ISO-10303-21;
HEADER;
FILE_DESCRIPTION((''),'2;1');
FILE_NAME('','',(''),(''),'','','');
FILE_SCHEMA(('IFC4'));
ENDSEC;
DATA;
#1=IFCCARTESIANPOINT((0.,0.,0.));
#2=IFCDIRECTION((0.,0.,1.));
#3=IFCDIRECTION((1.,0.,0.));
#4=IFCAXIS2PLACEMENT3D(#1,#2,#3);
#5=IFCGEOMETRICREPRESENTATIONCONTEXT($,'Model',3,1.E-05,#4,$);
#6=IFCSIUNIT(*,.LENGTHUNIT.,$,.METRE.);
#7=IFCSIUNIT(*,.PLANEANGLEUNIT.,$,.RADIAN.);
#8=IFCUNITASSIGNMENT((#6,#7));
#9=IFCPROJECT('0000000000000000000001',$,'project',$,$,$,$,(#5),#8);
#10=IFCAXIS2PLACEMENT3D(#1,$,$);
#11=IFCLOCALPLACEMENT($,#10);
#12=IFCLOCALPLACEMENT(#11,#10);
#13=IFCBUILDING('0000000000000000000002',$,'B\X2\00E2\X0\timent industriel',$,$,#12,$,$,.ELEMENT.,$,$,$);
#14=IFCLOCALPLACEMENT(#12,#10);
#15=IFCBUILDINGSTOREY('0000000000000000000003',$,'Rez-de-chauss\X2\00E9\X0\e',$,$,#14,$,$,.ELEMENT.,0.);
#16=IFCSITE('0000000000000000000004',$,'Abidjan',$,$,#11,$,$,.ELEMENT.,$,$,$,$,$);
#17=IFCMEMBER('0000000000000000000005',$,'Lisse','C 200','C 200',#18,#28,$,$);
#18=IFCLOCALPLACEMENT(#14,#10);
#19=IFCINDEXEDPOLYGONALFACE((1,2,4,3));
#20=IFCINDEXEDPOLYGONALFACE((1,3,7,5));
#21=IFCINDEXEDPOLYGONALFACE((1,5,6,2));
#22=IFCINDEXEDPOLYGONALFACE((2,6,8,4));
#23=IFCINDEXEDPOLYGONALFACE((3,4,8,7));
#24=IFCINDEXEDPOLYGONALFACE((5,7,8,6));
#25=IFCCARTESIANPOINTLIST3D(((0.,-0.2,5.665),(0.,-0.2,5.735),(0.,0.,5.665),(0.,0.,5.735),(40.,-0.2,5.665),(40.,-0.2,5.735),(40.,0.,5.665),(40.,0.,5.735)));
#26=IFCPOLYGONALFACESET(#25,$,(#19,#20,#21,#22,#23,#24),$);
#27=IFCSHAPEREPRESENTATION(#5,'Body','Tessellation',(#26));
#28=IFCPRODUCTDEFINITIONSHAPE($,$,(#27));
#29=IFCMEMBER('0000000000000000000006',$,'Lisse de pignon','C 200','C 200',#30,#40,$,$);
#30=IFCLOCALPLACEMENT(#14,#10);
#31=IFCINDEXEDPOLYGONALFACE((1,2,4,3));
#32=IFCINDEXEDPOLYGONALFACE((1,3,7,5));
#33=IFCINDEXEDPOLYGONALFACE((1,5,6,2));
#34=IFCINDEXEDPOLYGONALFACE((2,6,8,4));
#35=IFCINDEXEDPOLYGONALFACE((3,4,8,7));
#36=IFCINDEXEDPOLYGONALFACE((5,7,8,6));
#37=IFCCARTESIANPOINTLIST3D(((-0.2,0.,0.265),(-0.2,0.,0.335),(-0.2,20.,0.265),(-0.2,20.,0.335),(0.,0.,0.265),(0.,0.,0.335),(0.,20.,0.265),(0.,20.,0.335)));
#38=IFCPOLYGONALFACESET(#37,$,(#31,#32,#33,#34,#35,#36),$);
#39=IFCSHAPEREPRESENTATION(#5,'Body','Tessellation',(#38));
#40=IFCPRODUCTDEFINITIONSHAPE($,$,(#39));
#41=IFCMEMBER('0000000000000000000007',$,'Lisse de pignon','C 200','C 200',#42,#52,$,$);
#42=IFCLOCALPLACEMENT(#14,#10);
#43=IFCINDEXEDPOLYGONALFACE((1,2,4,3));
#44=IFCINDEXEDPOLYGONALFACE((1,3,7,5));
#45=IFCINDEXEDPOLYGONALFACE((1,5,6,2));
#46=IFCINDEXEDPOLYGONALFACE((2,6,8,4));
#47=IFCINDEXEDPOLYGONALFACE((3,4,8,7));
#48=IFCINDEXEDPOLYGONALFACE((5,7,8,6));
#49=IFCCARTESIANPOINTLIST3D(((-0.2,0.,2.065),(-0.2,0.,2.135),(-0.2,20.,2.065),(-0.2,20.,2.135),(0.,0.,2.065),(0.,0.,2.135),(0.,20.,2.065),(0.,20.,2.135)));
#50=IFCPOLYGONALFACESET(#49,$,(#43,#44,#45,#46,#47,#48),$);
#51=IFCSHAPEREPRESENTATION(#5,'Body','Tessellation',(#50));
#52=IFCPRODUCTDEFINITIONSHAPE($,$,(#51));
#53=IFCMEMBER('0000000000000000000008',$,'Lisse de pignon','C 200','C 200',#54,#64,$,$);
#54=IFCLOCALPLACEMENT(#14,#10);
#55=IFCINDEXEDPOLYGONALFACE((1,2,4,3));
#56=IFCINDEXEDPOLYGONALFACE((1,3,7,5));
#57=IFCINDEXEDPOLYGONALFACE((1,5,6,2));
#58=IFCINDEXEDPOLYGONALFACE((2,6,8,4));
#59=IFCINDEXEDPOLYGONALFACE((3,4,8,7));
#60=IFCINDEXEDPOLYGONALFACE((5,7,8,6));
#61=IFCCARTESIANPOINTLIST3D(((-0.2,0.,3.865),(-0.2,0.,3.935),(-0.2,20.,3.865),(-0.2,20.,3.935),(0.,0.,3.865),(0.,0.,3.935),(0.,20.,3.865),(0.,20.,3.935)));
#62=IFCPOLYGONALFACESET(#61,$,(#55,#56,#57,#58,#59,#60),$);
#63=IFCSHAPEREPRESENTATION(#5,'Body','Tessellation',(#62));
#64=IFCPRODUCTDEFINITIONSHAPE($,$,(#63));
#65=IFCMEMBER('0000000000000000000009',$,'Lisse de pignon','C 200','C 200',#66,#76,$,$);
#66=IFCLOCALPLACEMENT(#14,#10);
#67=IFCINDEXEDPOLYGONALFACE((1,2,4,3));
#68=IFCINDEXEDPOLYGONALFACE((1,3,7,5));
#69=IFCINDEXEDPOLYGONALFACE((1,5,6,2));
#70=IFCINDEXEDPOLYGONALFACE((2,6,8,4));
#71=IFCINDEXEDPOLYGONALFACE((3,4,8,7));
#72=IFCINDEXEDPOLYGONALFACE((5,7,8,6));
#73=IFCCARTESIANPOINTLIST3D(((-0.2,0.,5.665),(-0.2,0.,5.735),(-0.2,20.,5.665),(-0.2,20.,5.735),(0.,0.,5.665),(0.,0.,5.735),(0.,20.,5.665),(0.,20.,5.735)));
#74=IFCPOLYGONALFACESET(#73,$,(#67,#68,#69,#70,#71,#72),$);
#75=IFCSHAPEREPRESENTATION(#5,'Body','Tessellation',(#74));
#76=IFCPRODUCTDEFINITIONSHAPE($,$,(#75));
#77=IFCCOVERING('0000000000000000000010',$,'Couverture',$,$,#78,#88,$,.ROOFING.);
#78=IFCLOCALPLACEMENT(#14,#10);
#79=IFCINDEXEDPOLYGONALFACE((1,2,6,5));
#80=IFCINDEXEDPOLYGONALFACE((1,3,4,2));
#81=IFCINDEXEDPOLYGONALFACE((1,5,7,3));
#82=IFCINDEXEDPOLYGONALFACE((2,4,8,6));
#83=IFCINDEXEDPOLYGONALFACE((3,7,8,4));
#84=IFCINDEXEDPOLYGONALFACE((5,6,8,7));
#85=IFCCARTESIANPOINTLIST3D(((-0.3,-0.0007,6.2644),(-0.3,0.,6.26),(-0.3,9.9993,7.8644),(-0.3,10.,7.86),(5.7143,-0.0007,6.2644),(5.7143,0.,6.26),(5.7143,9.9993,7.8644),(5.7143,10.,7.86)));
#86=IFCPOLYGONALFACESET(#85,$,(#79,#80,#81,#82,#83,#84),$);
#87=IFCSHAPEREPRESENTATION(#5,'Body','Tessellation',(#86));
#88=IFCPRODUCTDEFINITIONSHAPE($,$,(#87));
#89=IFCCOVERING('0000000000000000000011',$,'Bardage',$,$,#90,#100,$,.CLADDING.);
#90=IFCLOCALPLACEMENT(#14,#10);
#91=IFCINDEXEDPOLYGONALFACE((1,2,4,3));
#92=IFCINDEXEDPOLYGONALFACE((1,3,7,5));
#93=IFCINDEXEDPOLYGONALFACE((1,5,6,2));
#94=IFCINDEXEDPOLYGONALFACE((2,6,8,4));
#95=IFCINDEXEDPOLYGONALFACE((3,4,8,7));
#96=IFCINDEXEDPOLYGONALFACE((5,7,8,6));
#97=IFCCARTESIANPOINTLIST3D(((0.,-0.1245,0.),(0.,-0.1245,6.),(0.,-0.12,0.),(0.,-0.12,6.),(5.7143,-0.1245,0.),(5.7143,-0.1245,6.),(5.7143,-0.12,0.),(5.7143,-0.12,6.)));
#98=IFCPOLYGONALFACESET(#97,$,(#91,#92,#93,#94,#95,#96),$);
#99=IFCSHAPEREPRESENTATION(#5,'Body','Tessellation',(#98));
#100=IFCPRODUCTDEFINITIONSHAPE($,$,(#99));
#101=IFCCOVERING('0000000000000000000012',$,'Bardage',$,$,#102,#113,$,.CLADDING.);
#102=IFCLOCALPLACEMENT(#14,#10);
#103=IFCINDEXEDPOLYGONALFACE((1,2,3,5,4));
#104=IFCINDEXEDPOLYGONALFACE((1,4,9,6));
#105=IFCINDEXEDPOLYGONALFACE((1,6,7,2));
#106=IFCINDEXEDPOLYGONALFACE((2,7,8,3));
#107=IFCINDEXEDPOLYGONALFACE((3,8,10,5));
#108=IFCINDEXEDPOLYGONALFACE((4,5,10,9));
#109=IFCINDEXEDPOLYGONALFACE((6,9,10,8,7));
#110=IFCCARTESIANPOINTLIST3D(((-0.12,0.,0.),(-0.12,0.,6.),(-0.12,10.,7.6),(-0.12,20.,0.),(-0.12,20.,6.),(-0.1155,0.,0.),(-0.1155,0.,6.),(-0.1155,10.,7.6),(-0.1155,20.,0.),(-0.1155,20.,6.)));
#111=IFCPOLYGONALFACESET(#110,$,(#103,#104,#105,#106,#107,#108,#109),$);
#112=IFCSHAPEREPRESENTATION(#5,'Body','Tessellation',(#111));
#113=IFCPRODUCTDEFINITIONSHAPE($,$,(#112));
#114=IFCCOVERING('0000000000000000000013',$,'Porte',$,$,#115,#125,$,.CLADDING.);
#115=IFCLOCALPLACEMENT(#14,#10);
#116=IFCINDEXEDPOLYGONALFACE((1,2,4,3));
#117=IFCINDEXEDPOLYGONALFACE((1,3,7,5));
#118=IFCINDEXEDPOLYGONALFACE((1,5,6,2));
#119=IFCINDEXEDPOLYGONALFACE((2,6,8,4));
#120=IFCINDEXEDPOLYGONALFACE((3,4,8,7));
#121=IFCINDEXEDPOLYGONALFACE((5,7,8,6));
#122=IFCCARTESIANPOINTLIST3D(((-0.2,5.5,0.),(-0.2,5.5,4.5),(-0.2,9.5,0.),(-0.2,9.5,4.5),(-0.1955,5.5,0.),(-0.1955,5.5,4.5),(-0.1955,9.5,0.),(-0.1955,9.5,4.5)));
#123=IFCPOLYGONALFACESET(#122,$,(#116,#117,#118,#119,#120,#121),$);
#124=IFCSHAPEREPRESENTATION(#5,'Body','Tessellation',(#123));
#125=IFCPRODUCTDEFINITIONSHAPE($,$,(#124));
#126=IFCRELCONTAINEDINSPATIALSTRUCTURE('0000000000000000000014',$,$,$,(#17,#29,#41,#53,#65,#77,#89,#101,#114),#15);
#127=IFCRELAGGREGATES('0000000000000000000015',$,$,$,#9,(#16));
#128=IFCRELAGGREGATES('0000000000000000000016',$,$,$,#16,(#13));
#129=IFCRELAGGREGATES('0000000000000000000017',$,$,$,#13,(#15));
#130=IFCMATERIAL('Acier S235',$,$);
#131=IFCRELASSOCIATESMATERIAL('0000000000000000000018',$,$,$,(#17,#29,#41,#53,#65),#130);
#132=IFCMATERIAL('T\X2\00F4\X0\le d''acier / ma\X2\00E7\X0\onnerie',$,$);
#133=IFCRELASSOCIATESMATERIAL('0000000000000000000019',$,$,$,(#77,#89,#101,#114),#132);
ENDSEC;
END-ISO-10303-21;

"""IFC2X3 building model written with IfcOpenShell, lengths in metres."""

from ifc_helpers import new_model, si_unit, frame, origin, origin_with_axes, origin_2d, place, context, project, spatial, polyline, rectangle, outline, extrude, material, element, save


model = new_model("IFC2X3")

# Units and contexts
model_context = context("Model", 3, precision=1e-05, world=origin_with_axes())
ifc_project = project(units=[si_unit("LENGTHUNIT", "METRE"), si_unit("PLANEANGLEUNIT", "RADIAN")], contexts=[model_context])

# Site, building, storey
site_placement = place(None, origin())
site = spatial("IfcSite", under=ifc_project, at=site_placement, Name="Abidjan", CompositionType="ELEMENT")
building_placement = place(site_placement, origin())
building = spatial("IfcBuilding", under=site, at=building_placement, Name="Bâtiment industriel", CompositionType="ELEMENT")
storey_placement = place(building_placement, origin())
storey = spatial("IfcBuildingStorey", under=building, at=storey_placement, Name="Rez-de-chaussée", CompositionType="ELEMENT", Elevation=0.0)

# Shared definitions
ifc_material_1 = material(Name="Acier S235")

# Members
for number, where, z_axis, x_axis, name in (
    (1, (0.0, -0.1, 5.7), (1.0, 0.0, 0.0), (0.0, 0.0, 1.0), "Lisse"),
):
    element("IfcMember", number, at=place(storey_placement, frame(where, z_axis=z_axis, x_axis=x_axis)), inside=storey, material=ifc_material_1, Name=name, Description="C 200", ObjectType="C 200", context=model_context, shape_type="SweptSolid", body=[
        extrude(rectangle(XDim=0.07, YDim=0.2, at=origin_2d()), origin(), (0.0, 0.0, 1.0), 40.0),
    ])
for number, where, z_axis, x_axis, name in (
    (2, (-0.1, 0.0, 0.3), (0.0, 1.0, 0.0), (0.0, 0.0, 1.0), "Lisse de pignon"),
    (3, (-0.1, 0.0, 2.1), (0.0, 1.0, 0.0), (0.0, 0.0, 1.0), "Lisse de pignon"),
    (4, (-0.1, 0.0, 3.9), (0.0, 1.0, 0.0), (0.0, 0.0, 1.0), "Lisse de pignon"),
    (5, (-0.1, 0.0, 5.7), (0.0, 1.0, 0.0), (0.0, 0.0, 1.0), "Lisse de pignon"),
):
    element("IfcMember", number, at=place(storey_placement, frame(where, z_axis=z_axis, x_axis=x_axis)), inside=storey, material=ifc_material_1, Name=name, Description="C 200", ObjectType="C 200", context=model_context, shape_type="SweptSolid", body=[
        extrude(rectangle(XDim=0.07, YDim=0.2, at=origin_2d()), origin(), (0.0, 0.0, 1.0), 20.0),
    ])

# Coverings
ifc_material_2 = material(Name="Tôle d'acier / maçonnerie")
covering_1_placement = place(storey_placement, frame((-0.3, 0.0, 6.26), z_axis=(0.0, -0.15799, 0.98744), x_axis=(1.0, 0.0, 0.0)))
element("IfcCovering", 6, at=covering_1_placement, inside=storey, material=ifc_material_2, Name="Couverture", PredefinedType="ROOFING", context=model_context, shape_type="SweptSolid", body=[
    extrude(outline(polyline([(0.0, 0.0), (6.0143, 0.0), (6.0143, 10.1272), (0.0, 10.1272), (0.0, 0.0)])), origin(), (0.0, 0.0, 1.0), 0.0045),
])
covering_2_placement = place(storey_placement, frame((0.0, -0.12, 0.0), z_axis=(0.0, -1.0, 0.0), x_axis=(1.0, 0.0, 0.0)))
element("IfcCovering", 7, at=covering_2_placement, inside=storey, material=ifc_material_2, Name="Bardage", PredefinedType="CLADDING", context=model_context, shape_type="SweptSolid", body=[
    extrude(outline(polyline([(0.0, 0.0), (5.7143, 0.0), (5.7143, 6.0), (0.0, 6.0), (0.0, 0.0)])), origin(), (0.0, 0.0, 1.0), 0.0045),
])
covering_3_placement = place(storey_placement, frame((-0.12, 0.0, 0.0), z_axis=(1.0, 0.0, 0.0), x_axis=(0.0, 1.0, 0.0)))
element("IfcCovering", 8, at=covering_3_placement, inside=storey, material=ifc_material_2, Name="Bardage", PredefinedType="CLADDING", context=model_context, shape_type="SweptSolid", body=[
    extrude(outline(polyline([(0.0, 0.0), (20.0, 0.0), (20.0, 6.0), (10.0, 7.6), (0.0, 6.0), (0.0, 0.0)])), origin(), (0.0, 0.0, 1.0), 0.0045),
])
covering_4_placement = place(storey_placement, frame((-0.2, 5.5, 0.0), z_axis=(1.0, 0.0, 0.0), x_axis=(0.0, 1.0, 0.0)))
element("IfcCovering", 9, at=covering_4_placement, inside=storey, material=ifc_material_2, Name="Porte", PredefinedType="CLADDING", context=model_context, shape_type="SweptSolid", body=[
    extrude(outline(polyline([(0.0, 0.0), (4.0, 0.0), (4.0, 4.5), (0.0, 4.5), (0.0, 0.0)])), origin(), (0.0, 0.0, 1.0), 0.0045),
])

save(model, "model.ifc")
